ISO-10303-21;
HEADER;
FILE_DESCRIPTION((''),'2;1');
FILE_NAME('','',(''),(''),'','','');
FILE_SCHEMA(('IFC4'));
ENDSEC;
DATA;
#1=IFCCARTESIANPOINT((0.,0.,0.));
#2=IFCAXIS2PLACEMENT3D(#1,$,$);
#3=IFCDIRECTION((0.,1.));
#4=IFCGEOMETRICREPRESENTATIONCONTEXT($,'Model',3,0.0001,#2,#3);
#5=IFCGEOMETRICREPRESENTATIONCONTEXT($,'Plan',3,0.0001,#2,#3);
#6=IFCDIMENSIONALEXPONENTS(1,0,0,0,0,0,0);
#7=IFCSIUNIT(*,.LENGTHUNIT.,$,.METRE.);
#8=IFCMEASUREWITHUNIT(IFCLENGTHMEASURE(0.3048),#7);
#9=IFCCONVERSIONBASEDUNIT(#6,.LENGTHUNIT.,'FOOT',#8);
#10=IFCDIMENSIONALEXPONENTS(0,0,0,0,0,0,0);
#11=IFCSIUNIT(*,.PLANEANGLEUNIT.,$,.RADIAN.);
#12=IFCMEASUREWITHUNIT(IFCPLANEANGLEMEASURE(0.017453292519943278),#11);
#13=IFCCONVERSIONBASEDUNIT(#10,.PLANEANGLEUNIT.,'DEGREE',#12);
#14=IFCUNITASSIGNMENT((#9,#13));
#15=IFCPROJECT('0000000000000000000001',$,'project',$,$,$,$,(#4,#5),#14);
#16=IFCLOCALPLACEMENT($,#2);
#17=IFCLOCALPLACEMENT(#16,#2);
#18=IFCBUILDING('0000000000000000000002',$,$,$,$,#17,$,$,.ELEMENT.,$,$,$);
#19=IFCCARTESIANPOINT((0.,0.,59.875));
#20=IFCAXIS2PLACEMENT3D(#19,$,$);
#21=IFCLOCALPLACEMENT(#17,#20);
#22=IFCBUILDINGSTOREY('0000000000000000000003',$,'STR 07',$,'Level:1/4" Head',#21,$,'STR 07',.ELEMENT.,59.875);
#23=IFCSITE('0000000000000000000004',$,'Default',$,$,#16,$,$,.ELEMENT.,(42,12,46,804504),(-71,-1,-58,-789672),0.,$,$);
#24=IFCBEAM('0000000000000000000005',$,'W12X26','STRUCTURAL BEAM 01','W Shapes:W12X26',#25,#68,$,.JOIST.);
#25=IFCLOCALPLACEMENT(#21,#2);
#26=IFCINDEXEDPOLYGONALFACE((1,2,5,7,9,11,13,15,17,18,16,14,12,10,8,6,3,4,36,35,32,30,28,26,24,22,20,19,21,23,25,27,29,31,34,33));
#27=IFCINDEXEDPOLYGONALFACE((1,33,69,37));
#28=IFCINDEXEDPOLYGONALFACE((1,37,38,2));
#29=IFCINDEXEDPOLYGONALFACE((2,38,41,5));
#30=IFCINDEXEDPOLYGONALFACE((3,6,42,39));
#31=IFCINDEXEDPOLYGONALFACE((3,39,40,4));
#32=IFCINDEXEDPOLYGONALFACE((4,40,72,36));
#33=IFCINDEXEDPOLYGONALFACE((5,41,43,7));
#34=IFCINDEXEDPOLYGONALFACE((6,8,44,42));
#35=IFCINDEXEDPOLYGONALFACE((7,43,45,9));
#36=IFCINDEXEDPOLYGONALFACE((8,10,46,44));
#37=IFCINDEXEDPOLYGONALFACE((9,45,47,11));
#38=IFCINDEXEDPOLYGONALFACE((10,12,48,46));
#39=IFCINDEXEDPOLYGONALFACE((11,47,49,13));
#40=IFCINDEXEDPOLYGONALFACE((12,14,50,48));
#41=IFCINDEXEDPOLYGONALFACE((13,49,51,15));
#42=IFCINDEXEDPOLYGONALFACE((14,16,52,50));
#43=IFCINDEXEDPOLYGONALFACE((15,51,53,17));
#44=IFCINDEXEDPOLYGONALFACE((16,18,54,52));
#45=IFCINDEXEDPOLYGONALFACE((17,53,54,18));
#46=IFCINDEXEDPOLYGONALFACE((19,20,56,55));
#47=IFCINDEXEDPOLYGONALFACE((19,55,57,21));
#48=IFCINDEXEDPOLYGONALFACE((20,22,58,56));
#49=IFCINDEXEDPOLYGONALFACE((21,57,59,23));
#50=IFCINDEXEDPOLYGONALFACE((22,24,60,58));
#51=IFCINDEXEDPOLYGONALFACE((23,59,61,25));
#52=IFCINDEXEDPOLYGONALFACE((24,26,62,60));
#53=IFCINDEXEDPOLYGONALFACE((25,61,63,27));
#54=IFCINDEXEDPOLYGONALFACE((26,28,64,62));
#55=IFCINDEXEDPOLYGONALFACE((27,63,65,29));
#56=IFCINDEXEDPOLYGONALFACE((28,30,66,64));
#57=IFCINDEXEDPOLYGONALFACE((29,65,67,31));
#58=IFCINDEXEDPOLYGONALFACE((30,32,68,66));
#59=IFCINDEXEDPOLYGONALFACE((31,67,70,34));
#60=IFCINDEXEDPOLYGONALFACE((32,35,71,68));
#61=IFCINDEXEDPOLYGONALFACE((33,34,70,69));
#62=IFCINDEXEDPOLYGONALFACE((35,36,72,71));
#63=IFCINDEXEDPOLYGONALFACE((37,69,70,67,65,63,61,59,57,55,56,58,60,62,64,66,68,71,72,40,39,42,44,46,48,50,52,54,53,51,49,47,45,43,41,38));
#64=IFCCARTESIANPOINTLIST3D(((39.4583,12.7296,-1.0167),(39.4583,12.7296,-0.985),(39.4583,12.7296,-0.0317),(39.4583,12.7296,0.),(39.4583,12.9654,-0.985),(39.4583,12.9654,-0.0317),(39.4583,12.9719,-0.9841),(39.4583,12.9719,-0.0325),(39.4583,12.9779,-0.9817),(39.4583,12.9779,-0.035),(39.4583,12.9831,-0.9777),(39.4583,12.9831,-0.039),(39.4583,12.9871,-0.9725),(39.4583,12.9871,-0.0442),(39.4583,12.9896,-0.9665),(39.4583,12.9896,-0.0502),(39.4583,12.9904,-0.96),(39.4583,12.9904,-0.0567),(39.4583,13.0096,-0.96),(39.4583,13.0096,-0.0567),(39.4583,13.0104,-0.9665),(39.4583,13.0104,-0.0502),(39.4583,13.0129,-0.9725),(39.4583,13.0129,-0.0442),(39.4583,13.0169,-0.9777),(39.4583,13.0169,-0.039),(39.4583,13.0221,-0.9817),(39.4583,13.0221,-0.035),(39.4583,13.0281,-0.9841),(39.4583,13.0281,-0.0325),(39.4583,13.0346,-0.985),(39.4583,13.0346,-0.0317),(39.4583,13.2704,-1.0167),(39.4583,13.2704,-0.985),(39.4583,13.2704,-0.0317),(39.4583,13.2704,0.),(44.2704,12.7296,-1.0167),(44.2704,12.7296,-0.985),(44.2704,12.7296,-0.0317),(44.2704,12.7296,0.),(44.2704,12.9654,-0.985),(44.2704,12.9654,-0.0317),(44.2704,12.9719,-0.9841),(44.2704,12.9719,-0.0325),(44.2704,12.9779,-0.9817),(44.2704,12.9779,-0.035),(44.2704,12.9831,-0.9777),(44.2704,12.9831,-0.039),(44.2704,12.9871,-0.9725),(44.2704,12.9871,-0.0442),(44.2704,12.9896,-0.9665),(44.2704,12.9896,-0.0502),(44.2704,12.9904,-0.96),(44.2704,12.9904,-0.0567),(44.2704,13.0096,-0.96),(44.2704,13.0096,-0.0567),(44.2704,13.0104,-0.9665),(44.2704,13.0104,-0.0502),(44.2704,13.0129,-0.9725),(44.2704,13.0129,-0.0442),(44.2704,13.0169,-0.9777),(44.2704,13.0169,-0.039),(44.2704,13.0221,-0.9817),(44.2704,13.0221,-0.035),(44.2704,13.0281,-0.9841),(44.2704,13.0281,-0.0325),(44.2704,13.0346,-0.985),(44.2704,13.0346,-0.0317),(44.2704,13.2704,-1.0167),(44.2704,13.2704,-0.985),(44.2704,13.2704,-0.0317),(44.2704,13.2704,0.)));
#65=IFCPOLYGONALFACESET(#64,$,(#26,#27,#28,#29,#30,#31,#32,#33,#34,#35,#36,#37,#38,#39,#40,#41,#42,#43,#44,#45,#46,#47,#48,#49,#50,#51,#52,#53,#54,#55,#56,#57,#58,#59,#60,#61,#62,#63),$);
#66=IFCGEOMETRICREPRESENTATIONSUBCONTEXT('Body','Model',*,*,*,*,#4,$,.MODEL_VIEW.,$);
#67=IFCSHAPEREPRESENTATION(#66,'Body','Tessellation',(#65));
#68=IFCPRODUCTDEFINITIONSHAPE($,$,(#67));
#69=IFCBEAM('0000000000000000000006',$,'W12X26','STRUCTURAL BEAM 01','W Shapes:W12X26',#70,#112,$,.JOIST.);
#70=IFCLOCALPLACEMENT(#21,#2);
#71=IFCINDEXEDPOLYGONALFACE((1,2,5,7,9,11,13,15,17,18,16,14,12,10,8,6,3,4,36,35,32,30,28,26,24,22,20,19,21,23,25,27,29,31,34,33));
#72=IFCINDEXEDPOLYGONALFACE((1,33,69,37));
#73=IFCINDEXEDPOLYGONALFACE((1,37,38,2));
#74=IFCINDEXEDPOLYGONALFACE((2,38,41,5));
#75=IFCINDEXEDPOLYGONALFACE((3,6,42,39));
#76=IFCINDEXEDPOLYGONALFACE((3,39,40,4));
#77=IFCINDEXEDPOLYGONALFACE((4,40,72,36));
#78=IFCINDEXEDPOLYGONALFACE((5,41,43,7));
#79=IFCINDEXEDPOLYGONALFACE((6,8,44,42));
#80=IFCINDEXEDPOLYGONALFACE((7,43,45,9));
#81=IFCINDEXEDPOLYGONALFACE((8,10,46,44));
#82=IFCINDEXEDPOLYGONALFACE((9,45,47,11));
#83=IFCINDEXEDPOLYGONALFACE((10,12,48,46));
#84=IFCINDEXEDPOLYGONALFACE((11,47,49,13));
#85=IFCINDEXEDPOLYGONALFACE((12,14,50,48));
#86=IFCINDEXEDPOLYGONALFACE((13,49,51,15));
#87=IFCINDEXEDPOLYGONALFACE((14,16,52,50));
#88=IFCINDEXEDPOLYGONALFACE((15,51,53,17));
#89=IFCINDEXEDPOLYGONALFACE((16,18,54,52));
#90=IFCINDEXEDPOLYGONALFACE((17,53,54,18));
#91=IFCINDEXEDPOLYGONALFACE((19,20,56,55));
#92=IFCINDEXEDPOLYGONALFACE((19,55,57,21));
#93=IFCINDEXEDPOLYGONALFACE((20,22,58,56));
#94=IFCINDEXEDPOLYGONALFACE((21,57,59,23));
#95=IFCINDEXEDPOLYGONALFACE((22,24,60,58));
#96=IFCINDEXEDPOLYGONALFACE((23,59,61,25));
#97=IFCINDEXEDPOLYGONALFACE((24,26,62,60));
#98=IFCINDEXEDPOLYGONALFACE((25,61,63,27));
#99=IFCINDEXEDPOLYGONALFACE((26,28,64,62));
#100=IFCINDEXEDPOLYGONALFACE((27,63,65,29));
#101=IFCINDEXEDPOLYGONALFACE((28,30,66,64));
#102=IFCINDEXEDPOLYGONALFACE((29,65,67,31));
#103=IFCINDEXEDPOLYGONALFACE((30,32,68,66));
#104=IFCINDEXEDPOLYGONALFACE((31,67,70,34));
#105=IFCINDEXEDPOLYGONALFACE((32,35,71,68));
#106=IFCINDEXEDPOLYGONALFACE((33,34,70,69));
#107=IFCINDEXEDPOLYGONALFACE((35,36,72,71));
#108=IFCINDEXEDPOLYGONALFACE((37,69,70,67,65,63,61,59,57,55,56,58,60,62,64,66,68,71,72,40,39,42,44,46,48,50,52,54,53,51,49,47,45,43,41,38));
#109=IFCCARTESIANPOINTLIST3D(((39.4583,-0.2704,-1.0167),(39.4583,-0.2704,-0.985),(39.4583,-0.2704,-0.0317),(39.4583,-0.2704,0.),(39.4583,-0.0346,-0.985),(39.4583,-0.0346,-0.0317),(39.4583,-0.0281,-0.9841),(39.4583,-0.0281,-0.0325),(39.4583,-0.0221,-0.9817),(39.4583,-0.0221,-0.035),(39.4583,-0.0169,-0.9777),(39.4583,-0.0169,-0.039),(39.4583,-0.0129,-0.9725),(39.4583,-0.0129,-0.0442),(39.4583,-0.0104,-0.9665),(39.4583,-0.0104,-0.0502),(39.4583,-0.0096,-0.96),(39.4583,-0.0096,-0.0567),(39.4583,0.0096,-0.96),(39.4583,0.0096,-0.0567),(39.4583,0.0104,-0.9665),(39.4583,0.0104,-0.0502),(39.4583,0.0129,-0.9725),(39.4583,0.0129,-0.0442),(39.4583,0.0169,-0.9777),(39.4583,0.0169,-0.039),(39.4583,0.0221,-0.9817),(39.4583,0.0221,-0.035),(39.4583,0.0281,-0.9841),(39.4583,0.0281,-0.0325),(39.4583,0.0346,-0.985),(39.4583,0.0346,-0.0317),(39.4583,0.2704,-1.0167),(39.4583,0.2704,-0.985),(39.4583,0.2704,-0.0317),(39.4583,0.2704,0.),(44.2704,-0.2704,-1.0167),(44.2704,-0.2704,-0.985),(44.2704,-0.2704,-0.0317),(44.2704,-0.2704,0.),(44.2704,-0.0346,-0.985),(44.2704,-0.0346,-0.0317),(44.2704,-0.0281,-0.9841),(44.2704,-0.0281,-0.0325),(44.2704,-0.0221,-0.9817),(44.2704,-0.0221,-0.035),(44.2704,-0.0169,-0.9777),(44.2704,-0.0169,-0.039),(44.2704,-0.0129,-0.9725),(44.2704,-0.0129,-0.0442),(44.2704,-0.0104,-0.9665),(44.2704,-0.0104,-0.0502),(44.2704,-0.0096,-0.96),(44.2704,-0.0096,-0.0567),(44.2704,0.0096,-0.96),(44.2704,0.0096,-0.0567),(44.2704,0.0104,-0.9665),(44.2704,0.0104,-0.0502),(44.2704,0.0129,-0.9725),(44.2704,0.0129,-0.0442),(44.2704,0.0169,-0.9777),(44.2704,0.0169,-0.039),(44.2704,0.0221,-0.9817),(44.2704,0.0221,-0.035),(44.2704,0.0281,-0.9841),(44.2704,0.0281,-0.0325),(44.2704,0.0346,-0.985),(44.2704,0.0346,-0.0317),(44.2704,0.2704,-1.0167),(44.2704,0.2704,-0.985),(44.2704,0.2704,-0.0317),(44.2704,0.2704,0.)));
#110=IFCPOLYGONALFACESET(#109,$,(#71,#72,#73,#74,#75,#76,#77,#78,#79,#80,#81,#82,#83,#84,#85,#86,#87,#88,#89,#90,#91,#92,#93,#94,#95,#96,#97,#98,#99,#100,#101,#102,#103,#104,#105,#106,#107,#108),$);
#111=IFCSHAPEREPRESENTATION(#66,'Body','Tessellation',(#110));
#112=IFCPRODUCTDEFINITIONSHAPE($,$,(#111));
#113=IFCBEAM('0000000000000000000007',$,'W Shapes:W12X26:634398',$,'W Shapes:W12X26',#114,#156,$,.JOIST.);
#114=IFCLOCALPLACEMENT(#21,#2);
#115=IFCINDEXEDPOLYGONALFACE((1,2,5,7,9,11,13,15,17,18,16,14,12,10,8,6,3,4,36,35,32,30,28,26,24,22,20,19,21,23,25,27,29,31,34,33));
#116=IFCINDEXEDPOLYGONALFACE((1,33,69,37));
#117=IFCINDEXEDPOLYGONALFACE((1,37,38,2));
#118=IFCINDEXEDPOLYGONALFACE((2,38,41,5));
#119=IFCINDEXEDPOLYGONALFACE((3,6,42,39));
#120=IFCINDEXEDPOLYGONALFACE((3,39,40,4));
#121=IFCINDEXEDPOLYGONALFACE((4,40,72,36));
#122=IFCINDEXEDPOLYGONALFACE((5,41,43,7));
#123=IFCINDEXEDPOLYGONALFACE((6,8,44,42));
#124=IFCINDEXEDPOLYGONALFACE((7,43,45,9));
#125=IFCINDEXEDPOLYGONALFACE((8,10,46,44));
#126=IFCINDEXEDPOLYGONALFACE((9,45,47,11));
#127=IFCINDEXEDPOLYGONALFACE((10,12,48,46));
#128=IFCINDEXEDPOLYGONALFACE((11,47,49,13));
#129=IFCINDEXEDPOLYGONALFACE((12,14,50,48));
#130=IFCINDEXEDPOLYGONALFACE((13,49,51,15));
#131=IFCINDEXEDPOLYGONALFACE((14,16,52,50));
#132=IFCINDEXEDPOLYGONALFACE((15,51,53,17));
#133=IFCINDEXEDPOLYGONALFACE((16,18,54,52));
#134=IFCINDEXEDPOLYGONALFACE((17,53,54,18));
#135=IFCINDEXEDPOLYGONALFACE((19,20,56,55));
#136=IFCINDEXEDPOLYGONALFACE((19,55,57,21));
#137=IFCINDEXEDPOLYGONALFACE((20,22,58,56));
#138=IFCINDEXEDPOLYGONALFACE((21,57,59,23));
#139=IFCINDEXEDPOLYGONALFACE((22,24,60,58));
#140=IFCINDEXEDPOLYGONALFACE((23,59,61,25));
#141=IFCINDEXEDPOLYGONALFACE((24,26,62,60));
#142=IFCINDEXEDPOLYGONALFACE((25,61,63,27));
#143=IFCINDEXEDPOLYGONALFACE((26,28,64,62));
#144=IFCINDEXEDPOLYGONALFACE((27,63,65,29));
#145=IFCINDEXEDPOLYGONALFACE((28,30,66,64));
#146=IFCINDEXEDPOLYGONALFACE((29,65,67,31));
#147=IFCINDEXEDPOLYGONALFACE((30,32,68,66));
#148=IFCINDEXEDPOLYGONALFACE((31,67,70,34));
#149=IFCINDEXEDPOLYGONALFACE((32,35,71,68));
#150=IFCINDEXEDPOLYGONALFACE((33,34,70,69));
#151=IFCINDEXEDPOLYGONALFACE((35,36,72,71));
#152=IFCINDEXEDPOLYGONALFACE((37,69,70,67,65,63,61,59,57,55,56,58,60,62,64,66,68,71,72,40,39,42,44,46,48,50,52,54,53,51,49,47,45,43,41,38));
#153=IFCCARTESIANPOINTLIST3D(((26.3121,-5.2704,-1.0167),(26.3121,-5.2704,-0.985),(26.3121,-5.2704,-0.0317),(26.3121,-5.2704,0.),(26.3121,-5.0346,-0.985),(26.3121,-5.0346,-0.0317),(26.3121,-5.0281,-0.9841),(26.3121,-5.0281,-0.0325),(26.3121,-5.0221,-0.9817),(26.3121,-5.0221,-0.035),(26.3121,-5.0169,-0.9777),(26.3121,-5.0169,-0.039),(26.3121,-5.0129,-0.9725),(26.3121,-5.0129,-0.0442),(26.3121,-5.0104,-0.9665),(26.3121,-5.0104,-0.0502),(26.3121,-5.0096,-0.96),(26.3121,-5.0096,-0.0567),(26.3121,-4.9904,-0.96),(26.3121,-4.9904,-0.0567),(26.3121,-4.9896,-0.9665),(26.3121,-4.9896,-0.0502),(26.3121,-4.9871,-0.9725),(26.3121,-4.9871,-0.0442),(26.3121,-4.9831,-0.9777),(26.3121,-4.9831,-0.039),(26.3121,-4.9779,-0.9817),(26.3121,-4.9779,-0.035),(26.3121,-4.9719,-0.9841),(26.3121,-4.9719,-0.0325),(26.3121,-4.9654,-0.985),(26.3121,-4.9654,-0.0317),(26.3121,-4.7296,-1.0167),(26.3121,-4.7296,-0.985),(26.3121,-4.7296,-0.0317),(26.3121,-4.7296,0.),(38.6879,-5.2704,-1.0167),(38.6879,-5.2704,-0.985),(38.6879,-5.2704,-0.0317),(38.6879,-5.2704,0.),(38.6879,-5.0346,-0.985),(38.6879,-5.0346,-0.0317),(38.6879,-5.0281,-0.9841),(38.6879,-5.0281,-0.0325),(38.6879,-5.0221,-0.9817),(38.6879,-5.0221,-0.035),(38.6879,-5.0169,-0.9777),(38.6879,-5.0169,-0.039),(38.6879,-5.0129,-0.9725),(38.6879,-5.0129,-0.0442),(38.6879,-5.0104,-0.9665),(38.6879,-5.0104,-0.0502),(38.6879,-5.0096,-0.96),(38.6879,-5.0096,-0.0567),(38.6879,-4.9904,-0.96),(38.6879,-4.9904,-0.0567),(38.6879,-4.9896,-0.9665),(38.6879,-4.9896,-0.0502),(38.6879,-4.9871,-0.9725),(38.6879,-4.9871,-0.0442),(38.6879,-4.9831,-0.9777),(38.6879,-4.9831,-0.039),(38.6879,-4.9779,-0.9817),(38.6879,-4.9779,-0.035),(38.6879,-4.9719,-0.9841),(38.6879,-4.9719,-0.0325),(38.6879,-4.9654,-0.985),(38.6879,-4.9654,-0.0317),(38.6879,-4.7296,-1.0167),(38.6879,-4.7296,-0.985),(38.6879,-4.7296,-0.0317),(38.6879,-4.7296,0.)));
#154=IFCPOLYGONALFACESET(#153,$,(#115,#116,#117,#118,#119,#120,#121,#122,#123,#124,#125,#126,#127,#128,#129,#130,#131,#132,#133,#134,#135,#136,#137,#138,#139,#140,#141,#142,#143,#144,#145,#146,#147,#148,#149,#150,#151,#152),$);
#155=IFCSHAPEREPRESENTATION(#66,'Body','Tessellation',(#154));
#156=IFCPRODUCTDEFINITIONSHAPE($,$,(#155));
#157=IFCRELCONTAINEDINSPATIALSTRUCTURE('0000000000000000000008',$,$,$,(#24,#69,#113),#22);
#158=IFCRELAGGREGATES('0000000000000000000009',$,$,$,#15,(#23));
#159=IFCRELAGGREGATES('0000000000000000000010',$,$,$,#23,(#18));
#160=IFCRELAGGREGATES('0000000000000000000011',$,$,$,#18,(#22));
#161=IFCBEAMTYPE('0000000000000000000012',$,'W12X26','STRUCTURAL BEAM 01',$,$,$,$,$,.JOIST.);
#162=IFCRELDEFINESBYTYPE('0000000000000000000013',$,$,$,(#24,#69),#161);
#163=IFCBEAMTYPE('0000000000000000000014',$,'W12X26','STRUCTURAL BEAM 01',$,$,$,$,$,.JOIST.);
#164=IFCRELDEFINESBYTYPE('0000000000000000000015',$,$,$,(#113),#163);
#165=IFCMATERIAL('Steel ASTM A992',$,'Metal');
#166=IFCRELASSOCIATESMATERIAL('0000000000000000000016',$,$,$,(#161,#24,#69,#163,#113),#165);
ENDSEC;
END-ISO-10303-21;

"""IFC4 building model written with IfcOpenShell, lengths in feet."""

from ifc_helpers import new_model, entity, si_unit, converted_unit, direction, frame, origin, place, context, subcontext, project, spatial, line, arc, indexed_curve, outline, extrude, source, transform, mapped, material, type_object, type_shapes, element, save


model = new_model("IFC4")

# Units and contexts
model_context = context("Model", 3, precision=0.0001, world=origin(), true_north=direction((0.0, 1.0)))
plan_context = context("Plan", 3, precision=0.0001, world=origin(), true_north=direction((0.0, 1.0)))
body_context = subcontext(model_context, "Body", "Model", "MODEL_VIEW")
ifc_project = project(units=[converted_unit("LENGTHUNIT", "FOOT", entity("IfcLengthMeasure", 0.3048), si_unit("LENGTHUNIT", "METRE"), dimensions=[1, 0, 0, 0, 0, 0, 0]), converted_unit("PLANEANGLEUNIT", "DEGREE", entity("IfcPlaneAngleMeasure", 0.017453292519943278), si_unit("PLANEANGLEUNIT", "RADIAN"), dimensions=[0, 0, 0, 0, 0, 0, 0])], contexts=[model_context, plan_context])

# Site, building, storey
site_placement = place(None, origin())
site = spatial("IfcSite", under=ifc_project, at=site_placement, Name="Default", CompositionType="ELEMENT", RefLatitude=(42, 12, 46, 804504), RefLongitude=(-71, -1, -58, -789672), RefElevation=0.0)
building_placement = place(site_placement, origin())
building = spatial("IfcBuilding", under=site, at=building_placement, CompositionType="ELEMENT")
storey_placement = place(building_placement, frame((0.0, 0.0, 59.875)))
storey = spatial("IfcBuildingStorey", under=building, at=storey_placement, Name="STR 07", ObjectType="Level:1/4\" Head", LongName="STR 07", CompositionType="ELEMENT", Elevation=59.875)

# Shared definitions
ifc_material = material(Name="Steel ASTM A992", Category="Metal")

# Beams
beam_type_1 = type_object("IfcBeamType", Name="W12X26", Description="STRUCTURAL BEAM 01", PredefinedType="JOIST", material=ifc_material)
shared_shape_1 = source(origin(), body_context, "Body", "SweptSolid", [
    extrude(outline(indexed_curve([(0.4767, -0.2704), (0.5083, -0.2704), (0.5083, 0.2704), (0.4767, 0.2704), (0.4767, 0.0346), (0.4693, 0.0169), (0.4517, 0.0096), (-0.4517, 0.0096), (-0.4693, 0.0169), (-0.4767, 0.0346), (-0.4767, 0.2704), (-0.5083, 0.2704), (-0.5083, -0.2704), (-0.4767, -0.2704), (-0.4767, -0.0346), (-0.4693, -0.0169), (-0.4517, -0.0096), (0.4517, -0.0096), (0.4693, -0.0169), (0.4767, -0.0346)], segments=[line(1, 2, 3, 4, 5), arc(5, 6, 7), line(7, 8), arc(8, 9, 10), line(10, 11, 12, 13, 14, 15), arc(15, 16, 17), line(17, 18), arc(18, 19, 20), line(20, 1)], self_intersect=False)), frame((-2.7704, 0.0, 0.0), z_axis=(1.0, 0.0, 0.0), x_axis=(0.0, 0.0, -1.0)), (0.0, 0.0, 1.0), 4.8121),
])
type_shapes(beam_type_1, [shared_shape_1])
for number, where, z_axis, x_axis, name in (
    (1, (41.5, 13.0, -0.5083), (0.0, 0.0, 1.0), (-1.0, 0.0, 0.0), "W12X26"),
    (2, (41.5, 0.0, -0.5083), (0.0, 0.0, 1.0), (-1.0, 0.0, 0.0), "W12X26"),
):
    element("IfcBeam", number, at=place(storey_placement, frame(where, z_axis=z_axis, x_axis=x_axis)), inside=storey, type_object=beam_type_1, material=ifc_material, Name=name, Description="STRUCTURAL BEAM 01", ObjectType="W Shapes:W12X26", PredefinedType="JOIST", context=body_context, shape_type="MappedRepresentation", body=[
        mapped(shared_shape_1, transform((0.0, 0.0, 0.0), scale=1.0)),
    ])
beam_type_2 = type_object("IfcBeamType", Name="W12X26", Description="STRUCTURAL BEAM 01", PredefinedType="JOIST", material=ifc_material)
shared_shape_2 = source(origin(), body_context, "Body", "SweptSolid", [
    extrude(outline(indexed_curve([(0.4767, -0.2704), (0.5083, -0.2704), (0.5083, 0.2704), (0.4767, 0.2704), (0.4767, 0.0346), (0.4693, 0.0169), (0.4517, 0.0096), (-0.4517, 0.0096), (-0.4693, 0.0169), (-0.4767, 0.0346), (-0.4767, 0.2704), (-0.5083, 0.2704), (-0.5083, -0.2704), (-0.4767, -0.2704), (-0.4767, -0.0346), (-0.4693, -0.0169), (-0.4517, -0.0096), (0.4517, -0.0096), (0.4693, -0.0169), (0.4767, -0.0346)], segments=[line(1, 2, 3, 4, 5), arc(5, 6, 7), line(7, 8), arc(8, 9, 10), line(10, 11, 12, 13, 14, 15), arc(15, 16, 17), line(17, 18), arc(18, 19, 20), line(20, 1)], self_intersect=False)), frame((-6.1879, 0.0, 0.0), z_axis=(1.0, 0.0, 0.0), x_axis=(0.0, 0.0, -1.0)), (0.0, 0.0, 1.0), 12.3758),
])
type_shapes(beam_type_2, [shared_shape_2])
beam_1_placement = place(storey_placement, frame((32.5, -5.0, -0.5083)))
element("IfcBeam", 3, at=beam_1_placement, inside=storey, type_object=beam_type_2, material=ifc_material, Name="W Shapes:W12X26:634398", ObjectType="W Shapes:W12X26", PredefinedType="JOIST", context=body_context, shape_type="MappedRepresentation", body=[
    mapped(shared_shape_2, transform((0.0, 0.0, 0.0), scale=1.0)),
])

save(model, "model.ifc")
